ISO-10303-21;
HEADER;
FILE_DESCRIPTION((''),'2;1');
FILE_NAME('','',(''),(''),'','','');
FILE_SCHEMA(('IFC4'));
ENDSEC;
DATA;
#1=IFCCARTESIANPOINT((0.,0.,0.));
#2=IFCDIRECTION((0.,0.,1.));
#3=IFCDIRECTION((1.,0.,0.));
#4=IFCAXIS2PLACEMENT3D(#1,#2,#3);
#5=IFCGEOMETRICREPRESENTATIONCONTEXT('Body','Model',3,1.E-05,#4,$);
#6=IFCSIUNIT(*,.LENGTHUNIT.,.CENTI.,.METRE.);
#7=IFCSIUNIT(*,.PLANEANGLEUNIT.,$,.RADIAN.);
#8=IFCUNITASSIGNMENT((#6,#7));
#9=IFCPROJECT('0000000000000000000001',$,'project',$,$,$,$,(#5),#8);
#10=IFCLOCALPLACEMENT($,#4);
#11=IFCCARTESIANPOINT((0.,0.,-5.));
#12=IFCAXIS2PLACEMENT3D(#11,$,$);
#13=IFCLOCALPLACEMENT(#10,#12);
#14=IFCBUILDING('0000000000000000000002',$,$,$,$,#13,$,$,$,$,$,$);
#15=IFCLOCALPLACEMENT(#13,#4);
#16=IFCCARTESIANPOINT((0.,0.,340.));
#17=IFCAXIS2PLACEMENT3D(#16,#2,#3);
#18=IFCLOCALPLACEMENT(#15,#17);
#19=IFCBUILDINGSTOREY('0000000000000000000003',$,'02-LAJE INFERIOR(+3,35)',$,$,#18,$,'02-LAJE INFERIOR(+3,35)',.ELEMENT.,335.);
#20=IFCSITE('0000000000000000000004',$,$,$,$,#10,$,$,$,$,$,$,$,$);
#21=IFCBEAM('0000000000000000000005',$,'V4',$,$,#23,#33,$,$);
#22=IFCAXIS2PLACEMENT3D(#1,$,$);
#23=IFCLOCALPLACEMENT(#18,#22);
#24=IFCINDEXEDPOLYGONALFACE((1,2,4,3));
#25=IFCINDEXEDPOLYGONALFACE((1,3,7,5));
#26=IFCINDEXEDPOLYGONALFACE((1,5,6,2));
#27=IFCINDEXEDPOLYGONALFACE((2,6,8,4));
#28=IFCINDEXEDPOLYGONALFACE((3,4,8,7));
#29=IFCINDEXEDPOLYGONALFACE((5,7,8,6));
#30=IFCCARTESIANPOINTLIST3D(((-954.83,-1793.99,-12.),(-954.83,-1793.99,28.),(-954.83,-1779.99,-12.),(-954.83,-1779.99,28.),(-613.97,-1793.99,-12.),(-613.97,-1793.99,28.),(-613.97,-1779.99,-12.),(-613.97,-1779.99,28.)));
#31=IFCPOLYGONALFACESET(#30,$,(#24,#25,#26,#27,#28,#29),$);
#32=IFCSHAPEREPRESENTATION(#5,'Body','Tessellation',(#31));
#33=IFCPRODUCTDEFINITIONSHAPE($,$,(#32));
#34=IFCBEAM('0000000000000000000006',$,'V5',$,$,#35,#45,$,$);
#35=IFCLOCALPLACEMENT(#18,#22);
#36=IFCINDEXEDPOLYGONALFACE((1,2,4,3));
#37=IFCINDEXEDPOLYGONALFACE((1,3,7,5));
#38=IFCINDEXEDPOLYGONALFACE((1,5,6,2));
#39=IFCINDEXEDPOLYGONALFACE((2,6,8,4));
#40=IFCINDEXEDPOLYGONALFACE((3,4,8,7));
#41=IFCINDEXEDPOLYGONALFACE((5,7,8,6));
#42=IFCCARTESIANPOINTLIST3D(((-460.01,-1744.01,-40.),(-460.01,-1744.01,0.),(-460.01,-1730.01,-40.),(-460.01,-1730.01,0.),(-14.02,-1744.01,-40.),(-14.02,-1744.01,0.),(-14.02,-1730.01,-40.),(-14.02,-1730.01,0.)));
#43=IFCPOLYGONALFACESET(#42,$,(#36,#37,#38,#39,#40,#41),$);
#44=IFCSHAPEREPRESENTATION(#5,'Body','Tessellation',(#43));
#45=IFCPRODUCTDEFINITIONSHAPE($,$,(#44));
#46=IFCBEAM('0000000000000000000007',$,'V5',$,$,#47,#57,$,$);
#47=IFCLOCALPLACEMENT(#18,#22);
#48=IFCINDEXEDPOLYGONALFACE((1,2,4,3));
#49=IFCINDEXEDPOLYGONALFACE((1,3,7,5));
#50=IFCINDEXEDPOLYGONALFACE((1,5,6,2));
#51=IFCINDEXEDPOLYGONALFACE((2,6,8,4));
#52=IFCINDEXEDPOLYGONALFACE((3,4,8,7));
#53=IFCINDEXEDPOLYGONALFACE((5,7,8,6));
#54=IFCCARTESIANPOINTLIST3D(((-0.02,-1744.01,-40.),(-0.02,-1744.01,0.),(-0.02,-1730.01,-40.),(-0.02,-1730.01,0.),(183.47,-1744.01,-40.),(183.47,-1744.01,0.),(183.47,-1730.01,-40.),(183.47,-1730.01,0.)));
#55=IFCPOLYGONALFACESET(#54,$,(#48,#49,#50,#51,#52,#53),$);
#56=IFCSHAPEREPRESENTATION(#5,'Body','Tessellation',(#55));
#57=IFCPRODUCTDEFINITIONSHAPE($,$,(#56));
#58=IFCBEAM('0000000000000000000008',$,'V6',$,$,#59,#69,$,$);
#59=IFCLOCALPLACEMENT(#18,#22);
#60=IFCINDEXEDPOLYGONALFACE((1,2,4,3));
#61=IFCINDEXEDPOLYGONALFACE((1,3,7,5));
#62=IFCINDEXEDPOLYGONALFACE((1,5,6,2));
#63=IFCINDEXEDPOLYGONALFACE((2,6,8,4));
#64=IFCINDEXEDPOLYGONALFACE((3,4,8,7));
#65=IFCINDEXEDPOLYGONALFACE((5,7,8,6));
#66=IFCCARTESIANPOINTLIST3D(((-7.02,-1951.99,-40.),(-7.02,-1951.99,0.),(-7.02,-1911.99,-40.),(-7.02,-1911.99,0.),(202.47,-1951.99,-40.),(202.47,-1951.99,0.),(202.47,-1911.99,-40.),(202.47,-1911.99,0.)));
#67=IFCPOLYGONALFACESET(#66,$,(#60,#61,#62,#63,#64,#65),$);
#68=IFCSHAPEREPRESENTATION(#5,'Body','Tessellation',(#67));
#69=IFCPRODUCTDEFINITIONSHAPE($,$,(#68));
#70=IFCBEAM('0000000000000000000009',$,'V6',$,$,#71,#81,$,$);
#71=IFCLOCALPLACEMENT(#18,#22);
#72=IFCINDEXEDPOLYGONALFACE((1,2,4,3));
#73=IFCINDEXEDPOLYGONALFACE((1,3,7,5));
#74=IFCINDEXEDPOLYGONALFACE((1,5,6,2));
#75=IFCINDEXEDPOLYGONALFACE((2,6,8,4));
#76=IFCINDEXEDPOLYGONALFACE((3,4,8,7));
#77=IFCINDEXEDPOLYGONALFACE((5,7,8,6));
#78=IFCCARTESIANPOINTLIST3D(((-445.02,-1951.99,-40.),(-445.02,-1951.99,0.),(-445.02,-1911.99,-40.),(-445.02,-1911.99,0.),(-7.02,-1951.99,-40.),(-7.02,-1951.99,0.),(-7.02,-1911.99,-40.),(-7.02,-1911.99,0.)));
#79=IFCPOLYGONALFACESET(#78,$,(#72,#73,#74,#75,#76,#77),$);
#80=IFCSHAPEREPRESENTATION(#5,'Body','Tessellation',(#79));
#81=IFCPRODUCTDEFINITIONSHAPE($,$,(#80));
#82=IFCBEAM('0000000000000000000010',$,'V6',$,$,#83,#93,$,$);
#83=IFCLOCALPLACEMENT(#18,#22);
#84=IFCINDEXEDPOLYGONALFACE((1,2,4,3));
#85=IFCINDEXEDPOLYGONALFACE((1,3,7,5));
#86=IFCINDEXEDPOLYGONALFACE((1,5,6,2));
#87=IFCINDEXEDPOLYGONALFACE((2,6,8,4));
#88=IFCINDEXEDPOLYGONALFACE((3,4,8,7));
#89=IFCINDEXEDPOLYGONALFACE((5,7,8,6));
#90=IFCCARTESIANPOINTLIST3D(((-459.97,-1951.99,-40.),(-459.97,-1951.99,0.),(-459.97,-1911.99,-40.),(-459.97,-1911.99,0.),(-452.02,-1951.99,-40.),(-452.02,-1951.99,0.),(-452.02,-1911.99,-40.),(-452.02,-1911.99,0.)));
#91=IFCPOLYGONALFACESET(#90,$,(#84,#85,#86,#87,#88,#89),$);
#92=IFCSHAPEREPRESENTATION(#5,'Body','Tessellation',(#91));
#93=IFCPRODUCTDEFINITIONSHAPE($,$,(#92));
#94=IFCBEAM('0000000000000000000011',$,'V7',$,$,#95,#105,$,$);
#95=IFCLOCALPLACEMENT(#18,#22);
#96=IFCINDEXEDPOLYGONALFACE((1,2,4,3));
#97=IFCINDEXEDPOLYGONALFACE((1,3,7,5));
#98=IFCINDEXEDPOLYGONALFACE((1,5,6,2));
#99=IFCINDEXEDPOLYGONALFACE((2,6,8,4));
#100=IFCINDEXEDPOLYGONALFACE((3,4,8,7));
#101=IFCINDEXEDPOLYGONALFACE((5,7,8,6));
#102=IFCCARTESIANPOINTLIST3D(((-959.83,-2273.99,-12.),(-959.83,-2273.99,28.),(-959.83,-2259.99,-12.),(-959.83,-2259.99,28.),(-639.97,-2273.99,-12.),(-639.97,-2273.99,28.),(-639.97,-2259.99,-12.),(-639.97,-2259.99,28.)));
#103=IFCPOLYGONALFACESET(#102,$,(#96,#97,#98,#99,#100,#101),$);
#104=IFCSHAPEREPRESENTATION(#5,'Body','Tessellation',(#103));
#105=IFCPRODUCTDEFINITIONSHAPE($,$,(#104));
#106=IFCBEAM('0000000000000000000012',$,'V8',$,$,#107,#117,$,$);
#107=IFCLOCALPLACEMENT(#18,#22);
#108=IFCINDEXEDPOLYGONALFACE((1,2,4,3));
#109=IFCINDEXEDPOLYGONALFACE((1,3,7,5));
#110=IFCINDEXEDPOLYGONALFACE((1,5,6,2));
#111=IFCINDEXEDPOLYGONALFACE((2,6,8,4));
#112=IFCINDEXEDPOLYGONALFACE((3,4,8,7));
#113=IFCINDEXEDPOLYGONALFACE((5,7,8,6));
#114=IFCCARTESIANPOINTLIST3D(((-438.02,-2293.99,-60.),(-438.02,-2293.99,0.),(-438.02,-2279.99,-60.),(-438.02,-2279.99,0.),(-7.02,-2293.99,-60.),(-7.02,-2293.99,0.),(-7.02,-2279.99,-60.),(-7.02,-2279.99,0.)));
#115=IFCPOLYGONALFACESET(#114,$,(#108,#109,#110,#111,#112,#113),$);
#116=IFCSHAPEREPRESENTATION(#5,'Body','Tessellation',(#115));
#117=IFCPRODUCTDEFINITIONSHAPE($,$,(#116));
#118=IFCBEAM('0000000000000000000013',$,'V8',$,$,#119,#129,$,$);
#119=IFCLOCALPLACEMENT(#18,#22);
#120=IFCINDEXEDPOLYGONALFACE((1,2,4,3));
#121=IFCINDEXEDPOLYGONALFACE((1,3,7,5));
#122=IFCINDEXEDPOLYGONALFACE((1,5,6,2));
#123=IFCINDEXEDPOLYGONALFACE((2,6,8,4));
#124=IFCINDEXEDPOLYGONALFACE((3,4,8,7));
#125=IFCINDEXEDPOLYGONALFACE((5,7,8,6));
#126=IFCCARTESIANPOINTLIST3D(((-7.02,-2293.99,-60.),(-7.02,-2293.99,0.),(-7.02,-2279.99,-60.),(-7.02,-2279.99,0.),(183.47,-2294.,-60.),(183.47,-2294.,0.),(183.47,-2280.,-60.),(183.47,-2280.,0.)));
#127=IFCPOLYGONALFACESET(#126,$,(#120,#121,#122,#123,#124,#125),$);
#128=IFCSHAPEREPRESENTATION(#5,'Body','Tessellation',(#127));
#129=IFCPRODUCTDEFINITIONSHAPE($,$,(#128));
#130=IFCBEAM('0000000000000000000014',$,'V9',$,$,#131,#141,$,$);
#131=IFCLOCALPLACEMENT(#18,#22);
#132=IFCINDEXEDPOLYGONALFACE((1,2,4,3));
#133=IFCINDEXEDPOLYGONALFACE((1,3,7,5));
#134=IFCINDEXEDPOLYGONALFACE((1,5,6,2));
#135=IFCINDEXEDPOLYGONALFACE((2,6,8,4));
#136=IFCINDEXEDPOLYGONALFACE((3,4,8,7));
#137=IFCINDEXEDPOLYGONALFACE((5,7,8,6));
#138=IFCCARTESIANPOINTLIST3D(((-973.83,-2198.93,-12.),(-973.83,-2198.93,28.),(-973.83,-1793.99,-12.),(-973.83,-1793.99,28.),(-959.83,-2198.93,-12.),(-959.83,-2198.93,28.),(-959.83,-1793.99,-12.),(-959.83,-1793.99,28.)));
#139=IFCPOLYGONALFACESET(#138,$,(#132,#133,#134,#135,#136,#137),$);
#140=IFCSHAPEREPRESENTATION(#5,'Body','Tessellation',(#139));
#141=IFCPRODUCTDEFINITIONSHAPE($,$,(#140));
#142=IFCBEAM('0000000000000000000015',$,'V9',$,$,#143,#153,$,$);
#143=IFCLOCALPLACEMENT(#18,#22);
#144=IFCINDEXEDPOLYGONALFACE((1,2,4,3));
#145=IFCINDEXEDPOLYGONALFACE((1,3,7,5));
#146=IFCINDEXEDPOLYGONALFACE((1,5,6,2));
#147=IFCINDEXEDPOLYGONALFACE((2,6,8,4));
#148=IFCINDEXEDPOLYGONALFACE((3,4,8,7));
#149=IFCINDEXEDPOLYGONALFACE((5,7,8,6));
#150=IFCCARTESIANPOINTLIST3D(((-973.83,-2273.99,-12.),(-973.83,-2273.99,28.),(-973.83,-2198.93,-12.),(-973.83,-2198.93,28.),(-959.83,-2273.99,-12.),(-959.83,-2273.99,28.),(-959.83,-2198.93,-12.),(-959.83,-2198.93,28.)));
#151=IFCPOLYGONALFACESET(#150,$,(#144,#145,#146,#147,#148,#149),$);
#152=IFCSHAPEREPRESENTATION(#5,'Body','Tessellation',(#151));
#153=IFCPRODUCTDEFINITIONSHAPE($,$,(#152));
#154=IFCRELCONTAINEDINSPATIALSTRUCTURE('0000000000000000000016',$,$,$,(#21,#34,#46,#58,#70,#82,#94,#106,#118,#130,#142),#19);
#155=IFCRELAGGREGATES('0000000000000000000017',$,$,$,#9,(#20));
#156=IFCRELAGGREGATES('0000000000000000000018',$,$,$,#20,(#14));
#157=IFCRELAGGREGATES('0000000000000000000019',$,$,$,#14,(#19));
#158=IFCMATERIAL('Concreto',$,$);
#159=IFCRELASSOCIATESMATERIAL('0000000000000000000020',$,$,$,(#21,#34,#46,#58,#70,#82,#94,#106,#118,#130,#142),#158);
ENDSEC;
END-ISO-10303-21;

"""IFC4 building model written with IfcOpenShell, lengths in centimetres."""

from ifc_helpers import new_model, si_unit, frame, origin_with_axes, origin_2d_with_axis, place, context, project, spatial, rectangle, extrude, material, element, save


model = new_model("IFC4")

# Units and contexts
model_context = context("Model", 3, precision=1e-05, world=origin_with_axes(), identifier="Body")
ifc_project = project(units=[si_unit("LENGTHUNIT", "METRE", prefix="CENTI"), si_unit("PLANEANGLEUNIT", "RADIAN")], contexts=[model_context])

# Site, building, storey
site_placement = place(None, origin_with_axes())
site = spatial("IfcSite", under=ifc_project, at=site_placement)
building_placement = place(site_placement, frame((0.0, 0.0, -5.0)))
building = spatial("IfcBuilding", under=site, at=building_placement)
placement = place(building_placement, origin_with_axes())
storey_placement = place(placement, frame((0.0, 0.0, 340.0), z_axis=(0.0, 0.0, 1.0), x_axis=(1.0, 0.0, 0.0)))
storey = spatial("IfcBuildingStorey", under=building, at=storey_placement, Name="02-LAJE INFERIOR(+3,35)", LongName="02-LAJE INFERIOR(+3,35)", CompositionType="ELEMENT", Elevation=335.0)

# Shared definitions
ifc_material = material(Name="Concreto")

# Beams
beam_1_placement = place(storey_placement, frame((-784.4, -1786.99, 28.0), z_axis=(0.0, 0.0, 1.0), x_axis=(1.0, 0.0, 0.0)))
element("IfcBeam", 1, at=beam_1_placement, inside=storey, material=ifc_material, Name="V4", context=model_context, shape_type="SolidModel", body=[
    extrude(rectangle(XDim=14.0, YDim=40.0, at=origin_2d_with_axis()), frame((-170.43, 0.0, -20.0), z_axis=(1.0, 0.0, 0.0), x_axis=(0.0, -1.0, 0.0)), (0.0, 0.0, 1.0), 340.86),
])
beam_2_placement = place(storey_placement, frame((-237.01, -1737.01, 0.0), z_axis=(0.0, 0.0, 1.0), x_axis=(1.0, 0.0, 0.0)))
element("IfcBeam", 2, at=beam_2_placement, inside=storey, material=ifc_material, Name="V5", context=model_context, shape_type="SolidModel", body=[
    extrude(rectangle(XDim=14.0, YDim=40.0, at=origin_2d_with_axis()), frame((-223.0, 0.0, -20.0), z_axis=(1.0, 0.0, 0.0), x_axis=(0.0, -1.0, 0.0)), (0.0, 0.0, 1.0), 445.99),
])
beam_3_placement = place(storey_placement, frame((91.72, -1737.01, 0.0), z_axis=(0.0, 0.0, 1.0), x_axis=(1.0, 0.0, 0.0)))
element("IfcBeam", 3, at=beam_3_placement, inside=storey, material=ifc_material, Name="V5", context=model_context, shape_type="SolidModel", body=[
    extrude(rectangle(XDim=14.0, YDim=40.0, at=origin_2d_with_axis()), frame((-91.75, 0.0, -20.0), z_axis=(1.0, 0.0, 0.0), x_axis=(0.0, -1.0, 0.0)), (0.0, 0.0, 1.0), 183.49),
])
beam_4_placement = place(storey_placement, frame((97.72, -1931.99, 0.0), z_axis=(0.0, 0.0, 1.0), x_axis=(1.0, 0.0, 0.0)))
element("IfcBeam", 4, at=beam_4_placement, inside=storey, material=ifc_material, Name="V6", context=model_context, shape_type="SolidModel", body=[
    extrude(rectangle(XDim=40.0, YDim=40.0, at=origin_2d_with_axis()), frame((-104.75, 0.0, -20.0), z_axis=(1.0, 0.0, 0.0), x_axis=(0.0, -1.0, 0.0)), (0.0, 0.0, 1.0), 209.49),
])
beam_5_placement = place(storey_placement, frame((-226.02, -1931.99, 0.0), z_axis=(0.0, 0.0, 1.0), x_axis=(1.0, 0.0, 0.0)))
element("IfcBeam", 5, at=beam_5_placement, inside=storey, material=ifc_material, Name="V6", context=model_context, shape_type="SolidModel", body=[
    extrude(rectangle(XDim=40.0, YDim=40.0, at=origin_2d_with_axis()), frame((-219.0, 0.0, -20.0), z_axis=(1.0, 0.0, 0.0), x_axis=(0.0, -1.0, 0.0)), (0.0, 0.0, 1.0), 438.0),
])
beam_6_placement = place(storey_placement, frame((-456.0, -1931.99, 0.0), z_axis=(0.0, 0.0, 1.0), x_axis=(1.0, 0.0, 0.0)))
element("IfcBeam", 6, at=beam_6_placement, inside=storey, material=ifc_material, Name="V6", context=model_context, shape_type="SolidModel", body=[
    extrude(rectangle(XDim=40.0, YDim=40.0, at=origin_2d_with_axis()), frame((-3.98, 0.0, -20.0), z_axis=(1.0, 0.0, 0.0), x_axis=(0.0, -1.0, 0.0)), (0.0, 0.0, 1.0), 7.95),
])
beam_7_placement = place(storey_placement, frame((-799.9, -2266.99, 28.0), z_axis=(0.0, 0.0, 1.0), x_axis=(1.0, 0.0, 0.0)))
element("IfcBeam", 7, at=beam_7_placement, inside=storey, material=ifc_material, Name="V7", context=model_context, shape_type="SolidModel", body=[
    extrude(rectangle(XDim=14.0, YDim=40.0, at=origin_2d_with_axis()), frame((-159.93, 0.0, -20.0), z_axis=(1.0, 0.0, 0.0), x_axis=(0.0, -1.0, 0.0)), (0.0, 0.0, 1.0), 319.86),
])
beam_8_placement = place(storey_placement, frame((-222.52, -2286.99, 0.0), z_axis=(0.0, 0.0, 1.0), x_axis=(1.0, 0.0, 0.0)))
element("IfcBeam", 8, at=beam_8_placement, inside=storey, material=ifc_material, Name="V8", context=model_context, shape_type="SolidModel", body=[
    extrude(rectangle(XDim=14.0, YDim=60.0, at=origin_2d_with_axis()), frame((-215.5, 0.0, -30.0), z_axis=(1.0, 0.0, 0.0), x_axis=(0.0, -1.0, 0.0)), (0.0, 0.0, 1.0), 431.0),
])
beam_9_placement = place(storey_placement, frame((88.22, -2286.99, 0.0), z_axis=(0.0, 0.0, 1.0), x_axis=(1.0, 0.0, 0.0)))
element("IfcBeam", 9, at=beam_9_placement, inside=storey, material=ifc_material, Name="V8", context=model_context, shape_type="SolidModel", body=[
    extrude(rectangle(XDim=14.0, YDim=60.0, at=origin_2d_with_axis()), frame((-95.25, 0.01, -30.0), z_axis=(1.0, -0.000052, 0.0), x_axis=(-0.000052, -1.0, 0.0)), (0.0, 0.0, 1.0), 190.49),
])
beam_10_placement = place(storey_placement, frame((-966.83, -1996.46, 28.0), z_axis=(0.0, 0.0, 1.0), x_axis=(1.0, 0.0, 0.0)))
element("IfcBeam", 10, at=beam_10_placement, inside=storey, material=ifc_material, Name="V9", context=model_context, shape_type="SolidModel", body=[
    extrude(rectangle(XDim=14.0, YDim=40.0, at=origin_2d_with_axis()), frame((0.0, -202.47, -20.0), z_axis=(0.0, 1.0, 0.0), x_axis=(1.0, 0.0, 0.0)), (0.0, 0.0, 1.0), 404.94),
])
beam_11_placement = place(storey_placement, frame((-966.83, -2236.46, 28.0), z_axis=(0.0, 0.0, 1.0), x_axis=(1.0, 0.0, 0.0)))
element("IfcBeam", 11, at=beam_11_placement, inside=storey, material=ifc_material, Name="V9", context=model_context, shape_type="SolidModel", body=[
    extrude(rectangle(XDim=14.0, YDim=40.0, at=origin_2d_with_axis()), frame((0.0, -37.53, -20.0), z_axis=(0.0, 1.0, 0.0), x_axis=(1.0, 0.0, 0.0)), (0.0, 0.0, 1.0), 75.06),
])

save(model, "model.ifc")
